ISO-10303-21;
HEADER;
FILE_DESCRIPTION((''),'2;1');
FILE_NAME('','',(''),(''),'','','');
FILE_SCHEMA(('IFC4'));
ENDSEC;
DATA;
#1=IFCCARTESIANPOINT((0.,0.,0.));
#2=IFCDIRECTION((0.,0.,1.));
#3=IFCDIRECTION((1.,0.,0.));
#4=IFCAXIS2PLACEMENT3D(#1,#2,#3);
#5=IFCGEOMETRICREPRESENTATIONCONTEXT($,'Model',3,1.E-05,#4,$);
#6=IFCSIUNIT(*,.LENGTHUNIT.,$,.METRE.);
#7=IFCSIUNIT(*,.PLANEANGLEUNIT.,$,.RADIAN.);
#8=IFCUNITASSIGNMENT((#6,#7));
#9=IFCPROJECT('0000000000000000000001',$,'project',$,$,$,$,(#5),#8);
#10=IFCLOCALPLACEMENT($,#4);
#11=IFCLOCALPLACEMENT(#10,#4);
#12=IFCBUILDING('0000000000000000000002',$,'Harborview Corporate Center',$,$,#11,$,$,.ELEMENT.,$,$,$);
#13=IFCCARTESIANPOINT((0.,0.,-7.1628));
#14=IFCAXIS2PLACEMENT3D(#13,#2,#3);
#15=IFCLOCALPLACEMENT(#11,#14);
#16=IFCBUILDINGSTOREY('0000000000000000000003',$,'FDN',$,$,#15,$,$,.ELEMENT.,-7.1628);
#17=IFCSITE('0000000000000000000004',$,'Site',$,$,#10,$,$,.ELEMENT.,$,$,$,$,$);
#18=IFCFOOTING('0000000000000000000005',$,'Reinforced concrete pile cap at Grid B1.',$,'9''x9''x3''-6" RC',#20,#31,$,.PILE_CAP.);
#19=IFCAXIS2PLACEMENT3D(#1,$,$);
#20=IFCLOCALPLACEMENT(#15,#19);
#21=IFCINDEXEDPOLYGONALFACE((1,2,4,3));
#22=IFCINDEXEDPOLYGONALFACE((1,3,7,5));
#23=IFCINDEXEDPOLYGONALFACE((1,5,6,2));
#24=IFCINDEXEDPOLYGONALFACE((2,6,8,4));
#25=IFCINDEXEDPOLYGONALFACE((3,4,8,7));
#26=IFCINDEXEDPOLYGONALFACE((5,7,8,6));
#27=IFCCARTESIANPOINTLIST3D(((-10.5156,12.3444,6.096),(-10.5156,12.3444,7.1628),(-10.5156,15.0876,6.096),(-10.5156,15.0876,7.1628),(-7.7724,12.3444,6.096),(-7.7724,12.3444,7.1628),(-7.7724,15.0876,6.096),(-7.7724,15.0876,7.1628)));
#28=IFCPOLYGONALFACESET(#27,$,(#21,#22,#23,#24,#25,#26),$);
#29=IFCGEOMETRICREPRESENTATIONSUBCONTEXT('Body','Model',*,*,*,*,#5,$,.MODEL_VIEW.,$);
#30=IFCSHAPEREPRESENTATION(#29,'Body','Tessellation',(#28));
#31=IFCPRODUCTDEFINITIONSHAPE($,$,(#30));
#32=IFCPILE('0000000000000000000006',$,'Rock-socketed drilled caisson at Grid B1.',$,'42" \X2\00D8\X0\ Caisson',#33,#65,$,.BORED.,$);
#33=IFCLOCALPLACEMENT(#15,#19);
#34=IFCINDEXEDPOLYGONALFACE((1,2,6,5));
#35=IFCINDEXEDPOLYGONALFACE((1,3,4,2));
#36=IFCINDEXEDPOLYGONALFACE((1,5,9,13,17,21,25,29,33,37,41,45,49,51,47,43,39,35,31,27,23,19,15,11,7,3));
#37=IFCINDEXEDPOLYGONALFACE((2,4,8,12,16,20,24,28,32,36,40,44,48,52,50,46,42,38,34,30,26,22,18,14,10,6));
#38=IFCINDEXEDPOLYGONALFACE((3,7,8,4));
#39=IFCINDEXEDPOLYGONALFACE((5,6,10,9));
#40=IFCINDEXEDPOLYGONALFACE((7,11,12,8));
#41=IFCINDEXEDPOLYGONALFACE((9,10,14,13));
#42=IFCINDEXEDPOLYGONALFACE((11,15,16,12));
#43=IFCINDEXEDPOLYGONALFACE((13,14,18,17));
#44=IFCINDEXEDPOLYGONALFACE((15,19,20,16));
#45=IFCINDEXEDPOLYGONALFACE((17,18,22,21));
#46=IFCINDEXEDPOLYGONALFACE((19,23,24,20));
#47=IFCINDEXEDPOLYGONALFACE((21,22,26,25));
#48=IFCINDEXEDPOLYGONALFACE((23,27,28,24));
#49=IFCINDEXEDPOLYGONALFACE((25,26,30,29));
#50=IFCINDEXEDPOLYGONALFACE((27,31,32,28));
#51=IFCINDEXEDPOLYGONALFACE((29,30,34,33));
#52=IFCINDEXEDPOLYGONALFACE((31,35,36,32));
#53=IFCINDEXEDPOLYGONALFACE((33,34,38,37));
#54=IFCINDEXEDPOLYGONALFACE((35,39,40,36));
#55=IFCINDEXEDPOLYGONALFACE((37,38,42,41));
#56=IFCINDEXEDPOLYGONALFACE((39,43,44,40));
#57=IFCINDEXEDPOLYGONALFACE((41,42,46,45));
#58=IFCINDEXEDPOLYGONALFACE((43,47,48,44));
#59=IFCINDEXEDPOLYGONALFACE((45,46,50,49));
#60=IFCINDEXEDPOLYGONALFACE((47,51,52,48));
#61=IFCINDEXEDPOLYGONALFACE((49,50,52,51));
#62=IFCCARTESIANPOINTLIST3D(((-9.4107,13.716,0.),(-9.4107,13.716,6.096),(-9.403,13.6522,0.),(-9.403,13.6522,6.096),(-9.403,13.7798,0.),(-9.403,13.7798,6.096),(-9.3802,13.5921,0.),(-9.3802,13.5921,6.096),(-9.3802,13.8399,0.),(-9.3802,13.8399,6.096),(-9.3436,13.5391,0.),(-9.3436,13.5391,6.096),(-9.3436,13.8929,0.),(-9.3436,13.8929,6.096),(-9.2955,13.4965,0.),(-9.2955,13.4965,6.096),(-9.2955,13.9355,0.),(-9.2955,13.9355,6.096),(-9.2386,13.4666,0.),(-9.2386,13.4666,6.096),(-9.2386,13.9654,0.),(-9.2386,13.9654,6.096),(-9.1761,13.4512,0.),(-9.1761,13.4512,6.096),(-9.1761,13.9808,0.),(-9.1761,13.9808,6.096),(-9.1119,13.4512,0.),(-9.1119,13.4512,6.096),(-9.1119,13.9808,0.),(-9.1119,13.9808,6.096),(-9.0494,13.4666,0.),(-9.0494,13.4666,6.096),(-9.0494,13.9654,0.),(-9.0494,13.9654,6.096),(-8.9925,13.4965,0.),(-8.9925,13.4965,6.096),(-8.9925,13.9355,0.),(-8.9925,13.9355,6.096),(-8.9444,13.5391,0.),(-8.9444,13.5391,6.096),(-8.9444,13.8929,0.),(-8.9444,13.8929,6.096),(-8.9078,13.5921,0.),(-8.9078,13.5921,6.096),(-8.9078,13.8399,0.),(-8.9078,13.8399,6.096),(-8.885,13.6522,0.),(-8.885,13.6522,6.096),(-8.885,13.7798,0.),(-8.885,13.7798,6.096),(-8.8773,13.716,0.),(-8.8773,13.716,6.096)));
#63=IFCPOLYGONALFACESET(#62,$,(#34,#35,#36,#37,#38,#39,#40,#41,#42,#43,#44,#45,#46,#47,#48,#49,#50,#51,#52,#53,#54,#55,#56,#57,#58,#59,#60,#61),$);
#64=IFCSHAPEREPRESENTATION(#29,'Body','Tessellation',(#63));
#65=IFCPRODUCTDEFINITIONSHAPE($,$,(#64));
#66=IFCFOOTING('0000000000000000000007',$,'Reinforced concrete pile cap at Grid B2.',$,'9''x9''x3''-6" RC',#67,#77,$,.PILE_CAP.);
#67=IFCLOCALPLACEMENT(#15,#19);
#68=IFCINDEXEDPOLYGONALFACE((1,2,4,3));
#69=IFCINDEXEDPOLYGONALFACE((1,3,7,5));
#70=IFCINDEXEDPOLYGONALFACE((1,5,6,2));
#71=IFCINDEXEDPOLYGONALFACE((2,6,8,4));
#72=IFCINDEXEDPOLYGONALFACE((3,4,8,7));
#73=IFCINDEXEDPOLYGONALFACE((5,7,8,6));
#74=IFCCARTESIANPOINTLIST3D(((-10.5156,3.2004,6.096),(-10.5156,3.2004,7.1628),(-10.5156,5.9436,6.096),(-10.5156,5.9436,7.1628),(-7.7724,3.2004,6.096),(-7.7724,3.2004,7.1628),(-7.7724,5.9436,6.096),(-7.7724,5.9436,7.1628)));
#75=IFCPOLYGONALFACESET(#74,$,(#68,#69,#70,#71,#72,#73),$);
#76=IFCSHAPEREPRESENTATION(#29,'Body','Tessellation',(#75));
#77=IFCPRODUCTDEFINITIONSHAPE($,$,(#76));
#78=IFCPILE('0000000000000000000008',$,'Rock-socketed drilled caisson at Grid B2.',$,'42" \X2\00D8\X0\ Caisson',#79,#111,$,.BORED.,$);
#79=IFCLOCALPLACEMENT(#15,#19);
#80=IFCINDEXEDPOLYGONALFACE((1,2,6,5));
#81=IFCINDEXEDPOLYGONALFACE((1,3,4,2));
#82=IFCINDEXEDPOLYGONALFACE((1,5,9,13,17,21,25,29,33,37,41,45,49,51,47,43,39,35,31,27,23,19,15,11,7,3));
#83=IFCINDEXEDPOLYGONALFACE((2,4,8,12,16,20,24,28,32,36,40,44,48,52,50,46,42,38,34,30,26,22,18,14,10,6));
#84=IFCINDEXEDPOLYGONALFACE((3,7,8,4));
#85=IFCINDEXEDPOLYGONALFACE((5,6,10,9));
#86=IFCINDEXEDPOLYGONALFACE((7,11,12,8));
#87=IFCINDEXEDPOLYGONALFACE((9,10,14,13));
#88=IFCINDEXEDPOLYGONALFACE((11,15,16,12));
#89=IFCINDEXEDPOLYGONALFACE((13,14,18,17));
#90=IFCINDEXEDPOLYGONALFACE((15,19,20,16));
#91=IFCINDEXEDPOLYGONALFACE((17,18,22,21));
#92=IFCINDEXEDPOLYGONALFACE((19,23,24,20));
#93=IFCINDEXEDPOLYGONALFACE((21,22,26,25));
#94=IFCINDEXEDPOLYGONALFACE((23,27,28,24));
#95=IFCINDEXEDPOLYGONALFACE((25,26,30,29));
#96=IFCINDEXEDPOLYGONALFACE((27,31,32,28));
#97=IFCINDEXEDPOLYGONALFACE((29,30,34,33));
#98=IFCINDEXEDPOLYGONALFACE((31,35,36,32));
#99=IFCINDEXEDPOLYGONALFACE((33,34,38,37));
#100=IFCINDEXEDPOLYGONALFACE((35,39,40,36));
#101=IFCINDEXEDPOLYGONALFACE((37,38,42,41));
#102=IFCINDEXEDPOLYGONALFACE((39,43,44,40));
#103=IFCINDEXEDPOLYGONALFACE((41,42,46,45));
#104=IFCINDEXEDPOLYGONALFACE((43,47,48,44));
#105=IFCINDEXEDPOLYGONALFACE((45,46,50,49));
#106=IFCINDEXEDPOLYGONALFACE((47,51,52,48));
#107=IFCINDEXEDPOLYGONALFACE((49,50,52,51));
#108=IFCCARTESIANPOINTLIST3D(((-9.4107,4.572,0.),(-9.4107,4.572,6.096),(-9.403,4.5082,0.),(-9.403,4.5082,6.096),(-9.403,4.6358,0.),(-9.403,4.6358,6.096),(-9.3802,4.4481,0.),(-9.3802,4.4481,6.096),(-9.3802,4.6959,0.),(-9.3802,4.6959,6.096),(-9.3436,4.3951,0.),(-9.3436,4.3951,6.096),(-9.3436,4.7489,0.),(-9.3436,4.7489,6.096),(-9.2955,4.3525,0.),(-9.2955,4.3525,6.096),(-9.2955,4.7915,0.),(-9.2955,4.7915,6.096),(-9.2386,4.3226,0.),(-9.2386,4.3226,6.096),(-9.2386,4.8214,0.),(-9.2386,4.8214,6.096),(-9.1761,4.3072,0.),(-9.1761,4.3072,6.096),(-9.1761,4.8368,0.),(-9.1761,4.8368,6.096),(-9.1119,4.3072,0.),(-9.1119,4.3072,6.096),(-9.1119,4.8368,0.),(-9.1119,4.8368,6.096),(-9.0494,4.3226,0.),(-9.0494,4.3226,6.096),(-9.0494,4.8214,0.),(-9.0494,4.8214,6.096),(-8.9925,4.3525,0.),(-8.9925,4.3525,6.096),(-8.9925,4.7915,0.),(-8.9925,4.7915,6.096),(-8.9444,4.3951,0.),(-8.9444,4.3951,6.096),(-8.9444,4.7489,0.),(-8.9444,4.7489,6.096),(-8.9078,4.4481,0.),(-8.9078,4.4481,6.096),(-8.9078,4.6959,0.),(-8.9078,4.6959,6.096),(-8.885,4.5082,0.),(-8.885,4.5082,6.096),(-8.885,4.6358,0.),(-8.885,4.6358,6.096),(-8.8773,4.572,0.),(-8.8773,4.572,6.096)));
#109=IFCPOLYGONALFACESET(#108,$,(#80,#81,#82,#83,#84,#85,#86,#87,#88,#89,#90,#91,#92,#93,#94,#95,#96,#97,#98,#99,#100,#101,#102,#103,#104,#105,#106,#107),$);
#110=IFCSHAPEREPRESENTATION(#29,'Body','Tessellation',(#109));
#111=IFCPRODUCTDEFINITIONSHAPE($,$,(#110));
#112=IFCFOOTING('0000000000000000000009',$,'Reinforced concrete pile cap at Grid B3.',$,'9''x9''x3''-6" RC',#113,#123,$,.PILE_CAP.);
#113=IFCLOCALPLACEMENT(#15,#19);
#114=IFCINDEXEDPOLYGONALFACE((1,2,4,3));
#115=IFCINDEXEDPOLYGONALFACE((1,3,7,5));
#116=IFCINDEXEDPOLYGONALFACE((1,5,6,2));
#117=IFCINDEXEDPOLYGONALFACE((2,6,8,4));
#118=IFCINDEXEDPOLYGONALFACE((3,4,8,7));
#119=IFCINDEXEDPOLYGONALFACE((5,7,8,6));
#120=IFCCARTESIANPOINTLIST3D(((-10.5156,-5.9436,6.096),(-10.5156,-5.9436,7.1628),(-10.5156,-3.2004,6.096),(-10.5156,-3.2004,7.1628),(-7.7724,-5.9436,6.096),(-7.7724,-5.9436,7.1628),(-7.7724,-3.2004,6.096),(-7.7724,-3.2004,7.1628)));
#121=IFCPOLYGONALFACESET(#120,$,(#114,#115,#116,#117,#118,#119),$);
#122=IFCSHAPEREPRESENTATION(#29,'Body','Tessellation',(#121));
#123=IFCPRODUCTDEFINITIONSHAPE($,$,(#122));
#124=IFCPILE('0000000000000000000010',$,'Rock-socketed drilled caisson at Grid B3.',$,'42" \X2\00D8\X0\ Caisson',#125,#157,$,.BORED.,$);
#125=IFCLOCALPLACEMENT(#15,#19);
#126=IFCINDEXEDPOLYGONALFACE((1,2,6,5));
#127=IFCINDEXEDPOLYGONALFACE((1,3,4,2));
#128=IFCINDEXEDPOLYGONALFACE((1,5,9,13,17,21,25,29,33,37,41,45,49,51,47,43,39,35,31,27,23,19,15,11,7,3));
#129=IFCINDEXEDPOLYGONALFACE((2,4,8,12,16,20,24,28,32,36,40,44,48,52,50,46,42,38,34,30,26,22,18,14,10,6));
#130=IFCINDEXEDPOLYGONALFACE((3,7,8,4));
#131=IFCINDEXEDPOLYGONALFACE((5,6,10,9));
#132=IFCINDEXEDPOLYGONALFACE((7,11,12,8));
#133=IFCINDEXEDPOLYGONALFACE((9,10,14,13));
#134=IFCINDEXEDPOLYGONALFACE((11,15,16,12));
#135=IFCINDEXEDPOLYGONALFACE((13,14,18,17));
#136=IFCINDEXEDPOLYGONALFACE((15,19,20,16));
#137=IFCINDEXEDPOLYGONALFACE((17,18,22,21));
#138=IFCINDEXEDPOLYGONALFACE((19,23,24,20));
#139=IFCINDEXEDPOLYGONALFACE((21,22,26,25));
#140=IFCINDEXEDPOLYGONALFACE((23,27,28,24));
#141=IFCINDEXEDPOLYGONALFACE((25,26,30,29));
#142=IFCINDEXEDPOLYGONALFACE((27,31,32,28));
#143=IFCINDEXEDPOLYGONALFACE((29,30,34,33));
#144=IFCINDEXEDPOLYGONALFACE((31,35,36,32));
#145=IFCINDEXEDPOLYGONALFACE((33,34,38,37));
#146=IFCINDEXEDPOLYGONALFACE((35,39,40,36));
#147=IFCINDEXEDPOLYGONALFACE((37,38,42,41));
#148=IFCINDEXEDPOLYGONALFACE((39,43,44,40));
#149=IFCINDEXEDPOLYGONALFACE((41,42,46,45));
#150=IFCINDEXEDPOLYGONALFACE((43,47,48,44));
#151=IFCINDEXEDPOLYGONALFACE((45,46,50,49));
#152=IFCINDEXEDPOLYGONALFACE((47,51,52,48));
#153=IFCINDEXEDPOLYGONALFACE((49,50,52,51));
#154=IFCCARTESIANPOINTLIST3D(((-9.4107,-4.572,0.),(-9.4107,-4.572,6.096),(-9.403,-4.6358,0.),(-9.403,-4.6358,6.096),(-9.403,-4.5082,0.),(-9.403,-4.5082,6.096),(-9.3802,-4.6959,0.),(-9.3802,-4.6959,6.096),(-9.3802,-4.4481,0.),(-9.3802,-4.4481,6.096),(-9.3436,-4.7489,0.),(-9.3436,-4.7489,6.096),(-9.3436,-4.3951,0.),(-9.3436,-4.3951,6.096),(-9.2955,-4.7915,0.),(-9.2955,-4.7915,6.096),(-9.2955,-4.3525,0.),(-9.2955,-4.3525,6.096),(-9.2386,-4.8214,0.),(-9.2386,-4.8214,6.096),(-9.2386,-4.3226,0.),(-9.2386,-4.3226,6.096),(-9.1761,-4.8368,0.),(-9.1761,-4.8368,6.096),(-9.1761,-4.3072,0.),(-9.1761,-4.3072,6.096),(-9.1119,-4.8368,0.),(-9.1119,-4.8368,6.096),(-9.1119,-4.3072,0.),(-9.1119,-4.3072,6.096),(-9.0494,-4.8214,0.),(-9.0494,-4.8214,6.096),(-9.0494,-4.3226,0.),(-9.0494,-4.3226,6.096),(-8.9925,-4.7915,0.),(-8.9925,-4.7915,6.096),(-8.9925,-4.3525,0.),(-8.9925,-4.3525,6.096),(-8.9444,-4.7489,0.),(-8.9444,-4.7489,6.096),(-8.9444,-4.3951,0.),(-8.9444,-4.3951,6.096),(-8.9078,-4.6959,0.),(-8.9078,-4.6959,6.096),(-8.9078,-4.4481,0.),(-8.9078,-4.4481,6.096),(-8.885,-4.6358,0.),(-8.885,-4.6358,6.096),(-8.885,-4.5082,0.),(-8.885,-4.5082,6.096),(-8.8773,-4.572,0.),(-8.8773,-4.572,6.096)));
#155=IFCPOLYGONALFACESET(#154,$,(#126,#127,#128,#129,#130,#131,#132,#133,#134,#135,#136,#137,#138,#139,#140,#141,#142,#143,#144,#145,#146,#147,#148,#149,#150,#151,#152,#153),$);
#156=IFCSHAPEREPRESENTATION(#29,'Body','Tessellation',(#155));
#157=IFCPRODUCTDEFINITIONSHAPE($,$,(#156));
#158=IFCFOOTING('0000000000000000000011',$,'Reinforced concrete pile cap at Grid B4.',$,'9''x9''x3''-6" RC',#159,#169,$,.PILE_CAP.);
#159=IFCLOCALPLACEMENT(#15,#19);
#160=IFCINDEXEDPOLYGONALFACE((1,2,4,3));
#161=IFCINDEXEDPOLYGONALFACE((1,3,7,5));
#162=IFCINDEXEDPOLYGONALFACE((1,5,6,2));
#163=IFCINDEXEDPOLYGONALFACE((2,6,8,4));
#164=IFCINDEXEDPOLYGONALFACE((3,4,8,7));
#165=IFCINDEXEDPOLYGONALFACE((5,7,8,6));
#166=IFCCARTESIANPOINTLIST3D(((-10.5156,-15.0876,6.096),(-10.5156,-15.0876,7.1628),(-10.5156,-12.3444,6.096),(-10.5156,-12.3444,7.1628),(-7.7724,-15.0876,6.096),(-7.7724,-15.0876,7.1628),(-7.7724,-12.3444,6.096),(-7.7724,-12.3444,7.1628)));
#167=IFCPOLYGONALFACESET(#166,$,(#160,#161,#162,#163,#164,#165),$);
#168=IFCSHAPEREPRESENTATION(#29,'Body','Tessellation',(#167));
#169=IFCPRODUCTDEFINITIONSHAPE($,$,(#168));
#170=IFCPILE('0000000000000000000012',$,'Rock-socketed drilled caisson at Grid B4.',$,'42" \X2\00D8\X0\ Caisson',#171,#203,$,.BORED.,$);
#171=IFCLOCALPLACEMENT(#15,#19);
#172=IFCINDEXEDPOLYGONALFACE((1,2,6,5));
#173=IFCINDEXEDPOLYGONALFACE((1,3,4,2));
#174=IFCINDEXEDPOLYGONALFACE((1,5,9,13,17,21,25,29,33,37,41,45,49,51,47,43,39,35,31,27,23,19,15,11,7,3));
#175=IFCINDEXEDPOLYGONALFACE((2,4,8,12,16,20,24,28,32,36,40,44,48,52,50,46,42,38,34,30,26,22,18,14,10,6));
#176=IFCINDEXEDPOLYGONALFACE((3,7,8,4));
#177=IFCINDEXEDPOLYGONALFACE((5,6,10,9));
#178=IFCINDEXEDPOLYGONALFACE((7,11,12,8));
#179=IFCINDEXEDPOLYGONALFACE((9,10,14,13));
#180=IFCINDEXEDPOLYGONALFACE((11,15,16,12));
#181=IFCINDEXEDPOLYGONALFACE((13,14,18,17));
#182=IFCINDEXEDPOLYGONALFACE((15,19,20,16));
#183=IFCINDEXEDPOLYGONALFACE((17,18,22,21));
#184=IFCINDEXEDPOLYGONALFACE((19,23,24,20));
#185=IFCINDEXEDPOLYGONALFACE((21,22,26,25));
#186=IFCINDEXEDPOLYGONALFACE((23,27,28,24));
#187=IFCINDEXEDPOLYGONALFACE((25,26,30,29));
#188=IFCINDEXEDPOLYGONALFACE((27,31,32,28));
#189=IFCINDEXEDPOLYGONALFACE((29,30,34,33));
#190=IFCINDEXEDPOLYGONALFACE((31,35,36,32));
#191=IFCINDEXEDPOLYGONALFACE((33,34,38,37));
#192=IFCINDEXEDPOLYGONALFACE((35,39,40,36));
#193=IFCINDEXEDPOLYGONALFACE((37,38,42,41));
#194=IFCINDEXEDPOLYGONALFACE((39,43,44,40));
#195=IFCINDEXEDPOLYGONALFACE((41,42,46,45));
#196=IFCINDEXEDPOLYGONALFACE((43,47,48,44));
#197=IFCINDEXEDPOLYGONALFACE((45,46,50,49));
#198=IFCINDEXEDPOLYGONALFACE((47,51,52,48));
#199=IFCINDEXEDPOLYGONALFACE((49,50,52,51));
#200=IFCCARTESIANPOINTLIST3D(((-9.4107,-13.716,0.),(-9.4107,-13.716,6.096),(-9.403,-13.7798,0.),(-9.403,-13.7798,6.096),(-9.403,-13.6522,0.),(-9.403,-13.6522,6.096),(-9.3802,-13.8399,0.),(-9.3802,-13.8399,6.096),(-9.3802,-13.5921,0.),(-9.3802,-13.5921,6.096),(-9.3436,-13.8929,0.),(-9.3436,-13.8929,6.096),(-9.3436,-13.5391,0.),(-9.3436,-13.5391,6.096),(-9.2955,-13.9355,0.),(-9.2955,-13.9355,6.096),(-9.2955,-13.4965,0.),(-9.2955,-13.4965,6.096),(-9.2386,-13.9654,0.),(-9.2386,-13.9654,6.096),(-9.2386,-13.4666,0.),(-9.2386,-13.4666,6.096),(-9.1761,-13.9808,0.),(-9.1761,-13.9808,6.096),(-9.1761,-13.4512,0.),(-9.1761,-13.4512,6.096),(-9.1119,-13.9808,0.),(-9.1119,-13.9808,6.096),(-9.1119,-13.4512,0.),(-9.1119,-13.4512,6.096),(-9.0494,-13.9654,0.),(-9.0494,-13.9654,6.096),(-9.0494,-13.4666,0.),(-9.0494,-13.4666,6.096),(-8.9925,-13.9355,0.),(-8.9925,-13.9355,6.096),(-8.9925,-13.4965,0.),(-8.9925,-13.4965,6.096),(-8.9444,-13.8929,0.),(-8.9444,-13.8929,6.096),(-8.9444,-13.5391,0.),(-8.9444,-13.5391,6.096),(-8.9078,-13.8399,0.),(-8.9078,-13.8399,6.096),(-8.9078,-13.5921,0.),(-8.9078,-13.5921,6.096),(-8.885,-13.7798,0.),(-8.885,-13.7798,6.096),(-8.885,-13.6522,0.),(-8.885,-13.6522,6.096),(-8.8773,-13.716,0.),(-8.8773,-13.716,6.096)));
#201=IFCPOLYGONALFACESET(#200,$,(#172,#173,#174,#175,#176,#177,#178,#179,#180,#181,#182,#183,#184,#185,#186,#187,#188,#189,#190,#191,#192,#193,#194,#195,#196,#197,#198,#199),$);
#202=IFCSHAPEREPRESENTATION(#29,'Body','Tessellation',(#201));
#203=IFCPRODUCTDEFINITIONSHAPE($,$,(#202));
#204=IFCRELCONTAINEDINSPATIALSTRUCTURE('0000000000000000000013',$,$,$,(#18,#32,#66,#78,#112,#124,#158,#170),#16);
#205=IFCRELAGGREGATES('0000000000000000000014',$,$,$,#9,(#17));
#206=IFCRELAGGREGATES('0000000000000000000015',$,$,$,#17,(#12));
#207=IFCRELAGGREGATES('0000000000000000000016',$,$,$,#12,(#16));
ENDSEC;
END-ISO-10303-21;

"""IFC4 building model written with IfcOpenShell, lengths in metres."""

from ifc_helpers import new_model, si_unit, frame, origin_with_axes, place, context, subcontext, project, spatial, rectangle, circle, extrude, element, save


model = new_model("IFC4")

# Units and contexts
model_context = context("Model", 3, precision=1e-05, world=origin_with_axes())
body_context = subcontext(model_context, "Body", "Model", "MODEL_VIEW")
ifc_project = project(units=[si_unit("LENGTHUNIT", "METRE"), si_unit("PLANEANGLEUNIT", "RADIAN")], contexts=[model_context])

# Site, building, storey
site_placement = place(None, origin_with_axes())
site = spatial("IfcSite", under=ifc_project, at=site_placement, Name="Site", CompositionType="ELEMENT")
building_placement = place(site_placement, origin_with_axes())
building = spatial("IfcBuilding", under=site, at=building_placement, Name="Harborview Corporate Center", CompositionType="ELEMENT")
storey_placement = place(building_placement, frame((0.0, 0.0, -7.1628), z_axis=(0.0, 0.0, 1.0), x_axis=(1.0, 0.0, 0.0)))
storey = spatial("IfcBuildingStorey", under=building, at=storey_placement, Name="FDN", CompositionType="ELEMENT", Elevation=-7.1628)

# Footing
footing_1_placement = place(storey_placement, frame((-9.144, 13.716, 6.096), z_axis=(0.0, 0.0, 1.0), x_axis=(1.0, 0.0, 0.0)))
element("IfcFooting", 1, at=footing_1_placement, inside=storey, Name="Reinforced concrete pile cap at Grid B1.", ObjectType="9'x9'x3'-6\" RC", PredefinedType="PILE_CAP", context=body_context, shape_type="SweptSolid", body=[
    extrude(rectangle(XDim=2.7432, YDim=2.7432), origin_with_axes(), (0.0, 0.0, 1.0), 1.0668),
])

# Pile
pile_1_placement = place(storey_placement, frame((-9.144, 13.716, 0.0), z_axis=(0.0, 0.0, 1.0), x_axis=(1.0, 0.0, 0.0)))
element("IfcPile", 2, at=pile_1_placement, inside=storey, Name="Rock-socketed drilled caisson at Grid B1.", ObjectType="42\" Ø Caisson", PredefinedType="BORED", context=body_context, shape_type="SweptSolid", body=[
    extrude(circle(Radius=0.2667), origin_with_axes(), (0.0, 0.0, 1.0), 6.096),
])

# Footing
footing_2_placement = place(storey_placement, frame((-9.144, 4.572, 6.096), z_axis=(0.0, 0.0, 1.0), x_axis=(1.0, 0.0, 0.0)))
element("IfcFooting", 3, at=footing_2_placement, inside=storey, Name="Reinforced concrete pile cap at Grid B2.", ObjectType="9'x9'x3'-6\" RC", PredefinedType="PILE_CAP", context=body_context, shape_type="SweptSolid", body=[
    extrude(rectangle(XDim=2.7432, YDim=2.7432), origin_with_axes(), (0.0, 0.0, 1.0), 1.0668),
])

# Pile
pile_2_placement = place(storey_placement, frame((-9.144, 4.572, 0.0), z_axis=(0.0, 0.0, 1.0), x_axis=(1.0, 0.0, 0.0)))
element("IfcPile", 4, at=pile_2_placement, inside=storey, Name="Rock-socketed drilled caisson at Grid B2.", ObjectType="42\" Ø Caisson", PredefinedType="BORED", context=body_context, shape_type="SweptSolid", body=[
    extrude(circle(Radius=0.2667), origin_with_axes(), (0.0, 0.0, 1.0), 6.096),
])

# Footing
footing_3_placement = place(storey_placement, frame((-9.144, -4.572, 6.096), z_axis=(0.0, 0.0, 1.0), x_axis=(1.0, 0.0, 0.0)))
element("IfcFooting", 5, at=footing_3_placement, inside=storey, Name="Reinforced concrete pile cap at Grid B3.", ObjectType="9'x9'x3'-6\" RC", PredefinedType="PILE_CAP", context=body_context, shape_type="SweptSolid", body=[
    extrude(rectangle(XDim=2.7432, YDim=2.7432), origin_with_axes(), (0.0, 0.0, 1.0), 1.0668),
])

# Pile
pile_3_placement = place(storey_placement, frame((-9.144, -4.572, 0.0), z_axis=(0.0, 0.0, 1.0), x_axis=(1.0, 0.0, 0.0)))
element("IfcPile", 6, at=pile_3_placement, inside=storey, Name="Rock-socketed drilled caisson at Grid B3.", ObjectType="42\" Ø Caisson", PredefinedType="BORED", context=body_context, shape_type="SweptSolid", body=[
    extrude(circle(Radius=0.2667), origin_with_axes(), (0.0, 0.0, 1.0), 6.096),
])

# Footing
footing_4_placement = place(storey_placement, frame((-9.144, -13.716, 6.096), z_axis=(0.0, 0.0, 1.0), x_axis=(1.0, 0.0, 0.0)))
element("IfcFooting", 7, at=footing_4_placement, inside=storey, Name="Reinforced concrete pile cap at Grid B4.", ObjectType="9'x9'x3'-6\" RC", PredefinedType="PILE_CAP", context=body_context, shape_type="SweptSolid", body=[
    extrude(rectangle(XDim=2.7432, YDim=2.7432), origin_with_axes(), (0.0, 0.0, 1.0), 1.0668),
])

# Pile
pile_4_placement = place(storey_placement, frame((-9.144, -13.716, 0.0), z_axis=(0.0, 0.0, 1.0), x_axis=(1.0, 0.0, 0.0)))
element("IfcPile", 8, at=pile_4_placement, inside=storey, Name="Rock-socketed drilled caisson at Grid B4.", ObjectType="42\" Ø Caisson", PredefinedType="BORED", context=body_context, shape_type="SweptSolid", body=[
    extrude(circle(Radius=0.2667), origin_with_axes(), (0.0, 0.0, 1.0), 6.096),
])

save(model, "model.ifc")
